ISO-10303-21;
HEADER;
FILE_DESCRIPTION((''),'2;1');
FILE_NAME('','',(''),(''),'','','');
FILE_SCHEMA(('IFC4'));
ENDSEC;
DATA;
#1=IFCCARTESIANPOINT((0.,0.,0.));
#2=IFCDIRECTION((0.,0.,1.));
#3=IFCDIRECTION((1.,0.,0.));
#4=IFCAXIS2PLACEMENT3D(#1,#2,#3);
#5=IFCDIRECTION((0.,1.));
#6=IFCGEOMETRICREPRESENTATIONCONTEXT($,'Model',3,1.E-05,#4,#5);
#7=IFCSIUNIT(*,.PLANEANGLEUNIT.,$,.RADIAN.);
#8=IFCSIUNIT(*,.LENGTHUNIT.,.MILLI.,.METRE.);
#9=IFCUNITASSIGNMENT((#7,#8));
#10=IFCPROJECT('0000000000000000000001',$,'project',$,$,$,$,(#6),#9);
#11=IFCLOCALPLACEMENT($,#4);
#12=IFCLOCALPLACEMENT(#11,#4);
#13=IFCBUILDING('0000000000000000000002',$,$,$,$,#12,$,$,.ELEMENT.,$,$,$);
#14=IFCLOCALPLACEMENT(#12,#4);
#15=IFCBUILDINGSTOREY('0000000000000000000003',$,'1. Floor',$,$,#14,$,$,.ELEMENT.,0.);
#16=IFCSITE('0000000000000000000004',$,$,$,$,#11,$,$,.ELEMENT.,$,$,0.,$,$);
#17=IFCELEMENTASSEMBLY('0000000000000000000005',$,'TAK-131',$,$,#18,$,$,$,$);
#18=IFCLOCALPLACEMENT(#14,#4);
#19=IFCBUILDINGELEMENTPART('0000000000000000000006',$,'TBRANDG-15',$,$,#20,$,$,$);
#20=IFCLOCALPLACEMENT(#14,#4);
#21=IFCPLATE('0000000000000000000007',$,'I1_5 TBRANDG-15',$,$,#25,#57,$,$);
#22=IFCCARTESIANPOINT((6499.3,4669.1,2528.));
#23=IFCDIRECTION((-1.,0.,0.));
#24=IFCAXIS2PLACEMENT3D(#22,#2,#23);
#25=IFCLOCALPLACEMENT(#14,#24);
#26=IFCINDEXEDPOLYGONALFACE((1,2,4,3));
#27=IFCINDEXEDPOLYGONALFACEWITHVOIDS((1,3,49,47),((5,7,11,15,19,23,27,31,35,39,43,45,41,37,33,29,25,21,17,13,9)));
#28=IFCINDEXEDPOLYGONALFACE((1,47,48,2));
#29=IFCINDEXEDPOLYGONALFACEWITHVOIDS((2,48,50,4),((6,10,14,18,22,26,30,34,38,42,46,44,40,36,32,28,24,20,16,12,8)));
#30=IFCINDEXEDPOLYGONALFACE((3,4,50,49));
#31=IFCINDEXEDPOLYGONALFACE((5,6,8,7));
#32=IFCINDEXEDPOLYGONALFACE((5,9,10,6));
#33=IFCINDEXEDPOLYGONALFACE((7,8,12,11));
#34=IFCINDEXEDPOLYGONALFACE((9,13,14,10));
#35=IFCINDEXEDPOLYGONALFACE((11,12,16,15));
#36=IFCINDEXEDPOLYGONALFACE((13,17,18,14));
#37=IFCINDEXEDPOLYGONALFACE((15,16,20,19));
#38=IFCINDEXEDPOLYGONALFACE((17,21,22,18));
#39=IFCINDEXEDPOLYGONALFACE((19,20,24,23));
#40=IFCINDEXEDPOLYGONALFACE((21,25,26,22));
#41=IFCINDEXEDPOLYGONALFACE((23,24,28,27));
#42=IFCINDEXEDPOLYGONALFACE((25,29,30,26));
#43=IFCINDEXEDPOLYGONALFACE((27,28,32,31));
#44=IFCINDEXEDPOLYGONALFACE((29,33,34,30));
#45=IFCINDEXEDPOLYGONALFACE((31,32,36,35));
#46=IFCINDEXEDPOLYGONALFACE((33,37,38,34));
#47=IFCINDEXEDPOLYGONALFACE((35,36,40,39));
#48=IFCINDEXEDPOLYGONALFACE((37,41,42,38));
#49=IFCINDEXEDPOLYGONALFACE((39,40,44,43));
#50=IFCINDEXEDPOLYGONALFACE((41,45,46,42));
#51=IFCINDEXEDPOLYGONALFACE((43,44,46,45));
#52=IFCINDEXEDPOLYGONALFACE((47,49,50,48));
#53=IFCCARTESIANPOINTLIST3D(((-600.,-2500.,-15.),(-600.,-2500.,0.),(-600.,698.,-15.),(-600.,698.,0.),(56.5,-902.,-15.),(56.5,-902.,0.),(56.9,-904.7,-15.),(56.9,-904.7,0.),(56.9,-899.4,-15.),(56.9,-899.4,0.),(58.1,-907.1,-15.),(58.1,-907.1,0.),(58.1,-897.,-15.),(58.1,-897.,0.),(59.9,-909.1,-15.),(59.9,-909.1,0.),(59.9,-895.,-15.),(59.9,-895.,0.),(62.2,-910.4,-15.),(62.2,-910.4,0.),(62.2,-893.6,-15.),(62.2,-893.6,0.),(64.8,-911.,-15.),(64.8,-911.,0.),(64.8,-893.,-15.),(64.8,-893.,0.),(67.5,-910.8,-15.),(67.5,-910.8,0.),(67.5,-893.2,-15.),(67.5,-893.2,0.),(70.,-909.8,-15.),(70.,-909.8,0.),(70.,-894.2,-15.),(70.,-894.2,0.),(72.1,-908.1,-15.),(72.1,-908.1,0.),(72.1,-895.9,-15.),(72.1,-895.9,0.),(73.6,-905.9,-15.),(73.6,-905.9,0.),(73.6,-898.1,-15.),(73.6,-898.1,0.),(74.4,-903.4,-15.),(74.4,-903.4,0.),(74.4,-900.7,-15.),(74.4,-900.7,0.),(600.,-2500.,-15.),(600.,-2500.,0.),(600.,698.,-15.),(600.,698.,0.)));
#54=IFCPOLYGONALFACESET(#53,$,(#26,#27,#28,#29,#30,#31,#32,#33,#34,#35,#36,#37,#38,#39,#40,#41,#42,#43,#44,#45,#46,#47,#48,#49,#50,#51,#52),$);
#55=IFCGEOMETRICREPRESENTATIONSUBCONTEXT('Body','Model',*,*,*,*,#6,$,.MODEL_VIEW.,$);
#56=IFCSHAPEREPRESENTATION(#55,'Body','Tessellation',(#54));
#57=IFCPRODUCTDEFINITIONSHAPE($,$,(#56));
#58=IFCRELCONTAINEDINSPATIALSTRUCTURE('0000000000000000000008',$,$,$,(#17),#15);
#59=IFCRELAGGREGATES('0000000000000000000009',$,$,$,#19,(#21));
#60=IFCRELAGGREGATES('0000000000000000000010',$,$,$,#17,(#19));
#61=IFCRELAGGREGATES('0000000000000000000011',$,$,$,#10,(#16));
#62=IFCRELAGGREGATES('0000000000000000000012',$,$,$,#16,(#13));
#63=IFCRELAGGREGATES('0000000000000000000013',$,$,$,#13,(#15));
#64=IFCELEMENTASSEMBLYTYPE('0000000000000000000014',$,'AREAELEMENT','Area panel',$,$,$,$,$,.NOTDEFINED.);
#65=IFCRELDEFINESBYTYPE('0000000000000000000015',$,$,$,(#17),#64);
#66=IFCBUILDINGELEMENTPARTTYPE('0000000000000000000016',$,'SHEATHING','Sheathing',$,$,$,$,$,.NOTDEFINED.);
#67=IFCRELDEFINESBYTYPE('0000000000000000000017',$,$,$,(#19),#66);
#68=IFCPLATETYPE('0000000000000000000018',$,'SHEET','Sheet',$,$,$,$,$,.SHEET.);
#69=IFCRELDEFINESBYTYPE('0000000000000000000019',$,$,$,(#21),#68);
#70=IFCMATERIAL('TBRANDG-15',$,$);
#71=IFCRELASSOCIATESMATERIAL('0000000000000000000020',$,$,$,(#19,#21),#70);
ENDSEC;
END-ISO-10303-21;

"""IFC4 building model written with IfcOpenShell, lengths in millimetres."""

from ifc_helpers import new_model, si_unit, direction, frame, origin_with_axes, origin_2d_with_axis, place, context, subcontext, project, spatial, rectangle, circle, extrude, boolean, material, type_object, element, aggregate, save


model = new_model("IFC4")

# Units and contexts
model_context = context("Model", 3, precision=1e-05, world=origin_with_axes(), true_north=direction((0.0, 1.0)))
body_context = subcontext(model_context, "Body", "Model", "MODEL_VIEW")
ifc_project = project(units=[si_unit("PLANEANGLEUNIT", "RADIAN"), si_unit("LENGTHUNIT", "METRE", prefix="MILLI")], contexts=[model_context])

# Site, building, storey
site_placement = place(None, origin_with_axes())
site = spatial("IfcSite", under=ifc_project, at=site_placement, CompositionType="ELEMENT", RefElevation=0.0)
building_placement = place(site_placement, origin_with_axes())
building = spatial("IfcBuilding", under=site, at=building_placement, CompositionType="ELEMENT")
storey_placement = place(building_placement, origin_with_axes())
storey = spatial("IfcBuildingStorey", under=building, at=storey_placement, Name="1. Floor", CompositionType="ELEMENT", Elevation=0.0)

# Element assembly
element_assembly_type_1 = type_object("IfcElementAssemblyType", Name="AREAELEMENT", Description="Area panel", PredefinedType="NOTDEFINED")
assembly_1_placement = place(storey_placement, origin_with_axes())
assembly_1 = element("IfcElementAssembly", 1, at=assembly_1_placement, inside=storey, type_object=element_assembly_type_1, Name="TAK-131")

# Shared definitions
building_element_part_type_1 = type_object("IfcBuildingElementPartType", Name="SHEATHING", Description="Sheathing", PredefinedType="NOTDEFINED")
plate_type_1 = type_object("IfcPlateType", Name="SHEET", Description="Sheet", PredefinedType="SHEET")

# Building element part, plate
ifc_material_1 = material(Name="TBRANDG-15")
building_element_part_1_placement = place(storey_placement, origin_with_axes())
building_element_part_1 = element("IfcBuildingElementPart", 2, at=building_element_part_1_placement, type_object=building_element_part_type_1, material=ifc_material_1, Name="TBRANDG-15")
plate_1_placement = place(storey_placement, frame((6499.3, 4669.1, 2528.0), z_axis=(0.0, 0.0, 1.0), x_axis=(-1.0, 0.0, 0.0)))
plate_1 = element("IfcPlate", 3, at=plate_1_placement, type_object=plate_type_1, material=ifc_material_1, Name="I1_5 TBRANDG-15", context=body_context, shape_type="CSG", body=[
    boolean("DIFFERENCE", boolean("DIFFERENCE", extrude(rectangle(XDim=15.0, YDim=1200.0, at=origin_2d_with_axis()), frame((0.0, -2500.0, -7.5), z_axis=(0.0, 1.0, 0.0), x_axis=(0.0, 0.0, 1.0)), (0.0, 0.0, 1.0), 3198.0), extrude(circle(Radius=9.0, at=origin_2d_with_axis()), frame((65.5, -902.0, 10.0), z_axis=(0.0, 0.0, 1.0), x_axis=(-1.0, 0.0, 0.0)), (0.0, 0.0, -1.0), 50.0)), extrude(circle(Radius=9.0, at=origin_2d_with_axis()), frame((65.5, -902.0, 10.0), z_axis=(0.0, 0.0, 1.0), x_axis=(-1.0, 0.0, 0.0)), (0.0, 0.0, -1.0), 50.0)),
])
aggregate(building_element_part_1, [plate_1])

aggregate(assembly_1, [building_element_part_1])

save(model, "model.ifc")
